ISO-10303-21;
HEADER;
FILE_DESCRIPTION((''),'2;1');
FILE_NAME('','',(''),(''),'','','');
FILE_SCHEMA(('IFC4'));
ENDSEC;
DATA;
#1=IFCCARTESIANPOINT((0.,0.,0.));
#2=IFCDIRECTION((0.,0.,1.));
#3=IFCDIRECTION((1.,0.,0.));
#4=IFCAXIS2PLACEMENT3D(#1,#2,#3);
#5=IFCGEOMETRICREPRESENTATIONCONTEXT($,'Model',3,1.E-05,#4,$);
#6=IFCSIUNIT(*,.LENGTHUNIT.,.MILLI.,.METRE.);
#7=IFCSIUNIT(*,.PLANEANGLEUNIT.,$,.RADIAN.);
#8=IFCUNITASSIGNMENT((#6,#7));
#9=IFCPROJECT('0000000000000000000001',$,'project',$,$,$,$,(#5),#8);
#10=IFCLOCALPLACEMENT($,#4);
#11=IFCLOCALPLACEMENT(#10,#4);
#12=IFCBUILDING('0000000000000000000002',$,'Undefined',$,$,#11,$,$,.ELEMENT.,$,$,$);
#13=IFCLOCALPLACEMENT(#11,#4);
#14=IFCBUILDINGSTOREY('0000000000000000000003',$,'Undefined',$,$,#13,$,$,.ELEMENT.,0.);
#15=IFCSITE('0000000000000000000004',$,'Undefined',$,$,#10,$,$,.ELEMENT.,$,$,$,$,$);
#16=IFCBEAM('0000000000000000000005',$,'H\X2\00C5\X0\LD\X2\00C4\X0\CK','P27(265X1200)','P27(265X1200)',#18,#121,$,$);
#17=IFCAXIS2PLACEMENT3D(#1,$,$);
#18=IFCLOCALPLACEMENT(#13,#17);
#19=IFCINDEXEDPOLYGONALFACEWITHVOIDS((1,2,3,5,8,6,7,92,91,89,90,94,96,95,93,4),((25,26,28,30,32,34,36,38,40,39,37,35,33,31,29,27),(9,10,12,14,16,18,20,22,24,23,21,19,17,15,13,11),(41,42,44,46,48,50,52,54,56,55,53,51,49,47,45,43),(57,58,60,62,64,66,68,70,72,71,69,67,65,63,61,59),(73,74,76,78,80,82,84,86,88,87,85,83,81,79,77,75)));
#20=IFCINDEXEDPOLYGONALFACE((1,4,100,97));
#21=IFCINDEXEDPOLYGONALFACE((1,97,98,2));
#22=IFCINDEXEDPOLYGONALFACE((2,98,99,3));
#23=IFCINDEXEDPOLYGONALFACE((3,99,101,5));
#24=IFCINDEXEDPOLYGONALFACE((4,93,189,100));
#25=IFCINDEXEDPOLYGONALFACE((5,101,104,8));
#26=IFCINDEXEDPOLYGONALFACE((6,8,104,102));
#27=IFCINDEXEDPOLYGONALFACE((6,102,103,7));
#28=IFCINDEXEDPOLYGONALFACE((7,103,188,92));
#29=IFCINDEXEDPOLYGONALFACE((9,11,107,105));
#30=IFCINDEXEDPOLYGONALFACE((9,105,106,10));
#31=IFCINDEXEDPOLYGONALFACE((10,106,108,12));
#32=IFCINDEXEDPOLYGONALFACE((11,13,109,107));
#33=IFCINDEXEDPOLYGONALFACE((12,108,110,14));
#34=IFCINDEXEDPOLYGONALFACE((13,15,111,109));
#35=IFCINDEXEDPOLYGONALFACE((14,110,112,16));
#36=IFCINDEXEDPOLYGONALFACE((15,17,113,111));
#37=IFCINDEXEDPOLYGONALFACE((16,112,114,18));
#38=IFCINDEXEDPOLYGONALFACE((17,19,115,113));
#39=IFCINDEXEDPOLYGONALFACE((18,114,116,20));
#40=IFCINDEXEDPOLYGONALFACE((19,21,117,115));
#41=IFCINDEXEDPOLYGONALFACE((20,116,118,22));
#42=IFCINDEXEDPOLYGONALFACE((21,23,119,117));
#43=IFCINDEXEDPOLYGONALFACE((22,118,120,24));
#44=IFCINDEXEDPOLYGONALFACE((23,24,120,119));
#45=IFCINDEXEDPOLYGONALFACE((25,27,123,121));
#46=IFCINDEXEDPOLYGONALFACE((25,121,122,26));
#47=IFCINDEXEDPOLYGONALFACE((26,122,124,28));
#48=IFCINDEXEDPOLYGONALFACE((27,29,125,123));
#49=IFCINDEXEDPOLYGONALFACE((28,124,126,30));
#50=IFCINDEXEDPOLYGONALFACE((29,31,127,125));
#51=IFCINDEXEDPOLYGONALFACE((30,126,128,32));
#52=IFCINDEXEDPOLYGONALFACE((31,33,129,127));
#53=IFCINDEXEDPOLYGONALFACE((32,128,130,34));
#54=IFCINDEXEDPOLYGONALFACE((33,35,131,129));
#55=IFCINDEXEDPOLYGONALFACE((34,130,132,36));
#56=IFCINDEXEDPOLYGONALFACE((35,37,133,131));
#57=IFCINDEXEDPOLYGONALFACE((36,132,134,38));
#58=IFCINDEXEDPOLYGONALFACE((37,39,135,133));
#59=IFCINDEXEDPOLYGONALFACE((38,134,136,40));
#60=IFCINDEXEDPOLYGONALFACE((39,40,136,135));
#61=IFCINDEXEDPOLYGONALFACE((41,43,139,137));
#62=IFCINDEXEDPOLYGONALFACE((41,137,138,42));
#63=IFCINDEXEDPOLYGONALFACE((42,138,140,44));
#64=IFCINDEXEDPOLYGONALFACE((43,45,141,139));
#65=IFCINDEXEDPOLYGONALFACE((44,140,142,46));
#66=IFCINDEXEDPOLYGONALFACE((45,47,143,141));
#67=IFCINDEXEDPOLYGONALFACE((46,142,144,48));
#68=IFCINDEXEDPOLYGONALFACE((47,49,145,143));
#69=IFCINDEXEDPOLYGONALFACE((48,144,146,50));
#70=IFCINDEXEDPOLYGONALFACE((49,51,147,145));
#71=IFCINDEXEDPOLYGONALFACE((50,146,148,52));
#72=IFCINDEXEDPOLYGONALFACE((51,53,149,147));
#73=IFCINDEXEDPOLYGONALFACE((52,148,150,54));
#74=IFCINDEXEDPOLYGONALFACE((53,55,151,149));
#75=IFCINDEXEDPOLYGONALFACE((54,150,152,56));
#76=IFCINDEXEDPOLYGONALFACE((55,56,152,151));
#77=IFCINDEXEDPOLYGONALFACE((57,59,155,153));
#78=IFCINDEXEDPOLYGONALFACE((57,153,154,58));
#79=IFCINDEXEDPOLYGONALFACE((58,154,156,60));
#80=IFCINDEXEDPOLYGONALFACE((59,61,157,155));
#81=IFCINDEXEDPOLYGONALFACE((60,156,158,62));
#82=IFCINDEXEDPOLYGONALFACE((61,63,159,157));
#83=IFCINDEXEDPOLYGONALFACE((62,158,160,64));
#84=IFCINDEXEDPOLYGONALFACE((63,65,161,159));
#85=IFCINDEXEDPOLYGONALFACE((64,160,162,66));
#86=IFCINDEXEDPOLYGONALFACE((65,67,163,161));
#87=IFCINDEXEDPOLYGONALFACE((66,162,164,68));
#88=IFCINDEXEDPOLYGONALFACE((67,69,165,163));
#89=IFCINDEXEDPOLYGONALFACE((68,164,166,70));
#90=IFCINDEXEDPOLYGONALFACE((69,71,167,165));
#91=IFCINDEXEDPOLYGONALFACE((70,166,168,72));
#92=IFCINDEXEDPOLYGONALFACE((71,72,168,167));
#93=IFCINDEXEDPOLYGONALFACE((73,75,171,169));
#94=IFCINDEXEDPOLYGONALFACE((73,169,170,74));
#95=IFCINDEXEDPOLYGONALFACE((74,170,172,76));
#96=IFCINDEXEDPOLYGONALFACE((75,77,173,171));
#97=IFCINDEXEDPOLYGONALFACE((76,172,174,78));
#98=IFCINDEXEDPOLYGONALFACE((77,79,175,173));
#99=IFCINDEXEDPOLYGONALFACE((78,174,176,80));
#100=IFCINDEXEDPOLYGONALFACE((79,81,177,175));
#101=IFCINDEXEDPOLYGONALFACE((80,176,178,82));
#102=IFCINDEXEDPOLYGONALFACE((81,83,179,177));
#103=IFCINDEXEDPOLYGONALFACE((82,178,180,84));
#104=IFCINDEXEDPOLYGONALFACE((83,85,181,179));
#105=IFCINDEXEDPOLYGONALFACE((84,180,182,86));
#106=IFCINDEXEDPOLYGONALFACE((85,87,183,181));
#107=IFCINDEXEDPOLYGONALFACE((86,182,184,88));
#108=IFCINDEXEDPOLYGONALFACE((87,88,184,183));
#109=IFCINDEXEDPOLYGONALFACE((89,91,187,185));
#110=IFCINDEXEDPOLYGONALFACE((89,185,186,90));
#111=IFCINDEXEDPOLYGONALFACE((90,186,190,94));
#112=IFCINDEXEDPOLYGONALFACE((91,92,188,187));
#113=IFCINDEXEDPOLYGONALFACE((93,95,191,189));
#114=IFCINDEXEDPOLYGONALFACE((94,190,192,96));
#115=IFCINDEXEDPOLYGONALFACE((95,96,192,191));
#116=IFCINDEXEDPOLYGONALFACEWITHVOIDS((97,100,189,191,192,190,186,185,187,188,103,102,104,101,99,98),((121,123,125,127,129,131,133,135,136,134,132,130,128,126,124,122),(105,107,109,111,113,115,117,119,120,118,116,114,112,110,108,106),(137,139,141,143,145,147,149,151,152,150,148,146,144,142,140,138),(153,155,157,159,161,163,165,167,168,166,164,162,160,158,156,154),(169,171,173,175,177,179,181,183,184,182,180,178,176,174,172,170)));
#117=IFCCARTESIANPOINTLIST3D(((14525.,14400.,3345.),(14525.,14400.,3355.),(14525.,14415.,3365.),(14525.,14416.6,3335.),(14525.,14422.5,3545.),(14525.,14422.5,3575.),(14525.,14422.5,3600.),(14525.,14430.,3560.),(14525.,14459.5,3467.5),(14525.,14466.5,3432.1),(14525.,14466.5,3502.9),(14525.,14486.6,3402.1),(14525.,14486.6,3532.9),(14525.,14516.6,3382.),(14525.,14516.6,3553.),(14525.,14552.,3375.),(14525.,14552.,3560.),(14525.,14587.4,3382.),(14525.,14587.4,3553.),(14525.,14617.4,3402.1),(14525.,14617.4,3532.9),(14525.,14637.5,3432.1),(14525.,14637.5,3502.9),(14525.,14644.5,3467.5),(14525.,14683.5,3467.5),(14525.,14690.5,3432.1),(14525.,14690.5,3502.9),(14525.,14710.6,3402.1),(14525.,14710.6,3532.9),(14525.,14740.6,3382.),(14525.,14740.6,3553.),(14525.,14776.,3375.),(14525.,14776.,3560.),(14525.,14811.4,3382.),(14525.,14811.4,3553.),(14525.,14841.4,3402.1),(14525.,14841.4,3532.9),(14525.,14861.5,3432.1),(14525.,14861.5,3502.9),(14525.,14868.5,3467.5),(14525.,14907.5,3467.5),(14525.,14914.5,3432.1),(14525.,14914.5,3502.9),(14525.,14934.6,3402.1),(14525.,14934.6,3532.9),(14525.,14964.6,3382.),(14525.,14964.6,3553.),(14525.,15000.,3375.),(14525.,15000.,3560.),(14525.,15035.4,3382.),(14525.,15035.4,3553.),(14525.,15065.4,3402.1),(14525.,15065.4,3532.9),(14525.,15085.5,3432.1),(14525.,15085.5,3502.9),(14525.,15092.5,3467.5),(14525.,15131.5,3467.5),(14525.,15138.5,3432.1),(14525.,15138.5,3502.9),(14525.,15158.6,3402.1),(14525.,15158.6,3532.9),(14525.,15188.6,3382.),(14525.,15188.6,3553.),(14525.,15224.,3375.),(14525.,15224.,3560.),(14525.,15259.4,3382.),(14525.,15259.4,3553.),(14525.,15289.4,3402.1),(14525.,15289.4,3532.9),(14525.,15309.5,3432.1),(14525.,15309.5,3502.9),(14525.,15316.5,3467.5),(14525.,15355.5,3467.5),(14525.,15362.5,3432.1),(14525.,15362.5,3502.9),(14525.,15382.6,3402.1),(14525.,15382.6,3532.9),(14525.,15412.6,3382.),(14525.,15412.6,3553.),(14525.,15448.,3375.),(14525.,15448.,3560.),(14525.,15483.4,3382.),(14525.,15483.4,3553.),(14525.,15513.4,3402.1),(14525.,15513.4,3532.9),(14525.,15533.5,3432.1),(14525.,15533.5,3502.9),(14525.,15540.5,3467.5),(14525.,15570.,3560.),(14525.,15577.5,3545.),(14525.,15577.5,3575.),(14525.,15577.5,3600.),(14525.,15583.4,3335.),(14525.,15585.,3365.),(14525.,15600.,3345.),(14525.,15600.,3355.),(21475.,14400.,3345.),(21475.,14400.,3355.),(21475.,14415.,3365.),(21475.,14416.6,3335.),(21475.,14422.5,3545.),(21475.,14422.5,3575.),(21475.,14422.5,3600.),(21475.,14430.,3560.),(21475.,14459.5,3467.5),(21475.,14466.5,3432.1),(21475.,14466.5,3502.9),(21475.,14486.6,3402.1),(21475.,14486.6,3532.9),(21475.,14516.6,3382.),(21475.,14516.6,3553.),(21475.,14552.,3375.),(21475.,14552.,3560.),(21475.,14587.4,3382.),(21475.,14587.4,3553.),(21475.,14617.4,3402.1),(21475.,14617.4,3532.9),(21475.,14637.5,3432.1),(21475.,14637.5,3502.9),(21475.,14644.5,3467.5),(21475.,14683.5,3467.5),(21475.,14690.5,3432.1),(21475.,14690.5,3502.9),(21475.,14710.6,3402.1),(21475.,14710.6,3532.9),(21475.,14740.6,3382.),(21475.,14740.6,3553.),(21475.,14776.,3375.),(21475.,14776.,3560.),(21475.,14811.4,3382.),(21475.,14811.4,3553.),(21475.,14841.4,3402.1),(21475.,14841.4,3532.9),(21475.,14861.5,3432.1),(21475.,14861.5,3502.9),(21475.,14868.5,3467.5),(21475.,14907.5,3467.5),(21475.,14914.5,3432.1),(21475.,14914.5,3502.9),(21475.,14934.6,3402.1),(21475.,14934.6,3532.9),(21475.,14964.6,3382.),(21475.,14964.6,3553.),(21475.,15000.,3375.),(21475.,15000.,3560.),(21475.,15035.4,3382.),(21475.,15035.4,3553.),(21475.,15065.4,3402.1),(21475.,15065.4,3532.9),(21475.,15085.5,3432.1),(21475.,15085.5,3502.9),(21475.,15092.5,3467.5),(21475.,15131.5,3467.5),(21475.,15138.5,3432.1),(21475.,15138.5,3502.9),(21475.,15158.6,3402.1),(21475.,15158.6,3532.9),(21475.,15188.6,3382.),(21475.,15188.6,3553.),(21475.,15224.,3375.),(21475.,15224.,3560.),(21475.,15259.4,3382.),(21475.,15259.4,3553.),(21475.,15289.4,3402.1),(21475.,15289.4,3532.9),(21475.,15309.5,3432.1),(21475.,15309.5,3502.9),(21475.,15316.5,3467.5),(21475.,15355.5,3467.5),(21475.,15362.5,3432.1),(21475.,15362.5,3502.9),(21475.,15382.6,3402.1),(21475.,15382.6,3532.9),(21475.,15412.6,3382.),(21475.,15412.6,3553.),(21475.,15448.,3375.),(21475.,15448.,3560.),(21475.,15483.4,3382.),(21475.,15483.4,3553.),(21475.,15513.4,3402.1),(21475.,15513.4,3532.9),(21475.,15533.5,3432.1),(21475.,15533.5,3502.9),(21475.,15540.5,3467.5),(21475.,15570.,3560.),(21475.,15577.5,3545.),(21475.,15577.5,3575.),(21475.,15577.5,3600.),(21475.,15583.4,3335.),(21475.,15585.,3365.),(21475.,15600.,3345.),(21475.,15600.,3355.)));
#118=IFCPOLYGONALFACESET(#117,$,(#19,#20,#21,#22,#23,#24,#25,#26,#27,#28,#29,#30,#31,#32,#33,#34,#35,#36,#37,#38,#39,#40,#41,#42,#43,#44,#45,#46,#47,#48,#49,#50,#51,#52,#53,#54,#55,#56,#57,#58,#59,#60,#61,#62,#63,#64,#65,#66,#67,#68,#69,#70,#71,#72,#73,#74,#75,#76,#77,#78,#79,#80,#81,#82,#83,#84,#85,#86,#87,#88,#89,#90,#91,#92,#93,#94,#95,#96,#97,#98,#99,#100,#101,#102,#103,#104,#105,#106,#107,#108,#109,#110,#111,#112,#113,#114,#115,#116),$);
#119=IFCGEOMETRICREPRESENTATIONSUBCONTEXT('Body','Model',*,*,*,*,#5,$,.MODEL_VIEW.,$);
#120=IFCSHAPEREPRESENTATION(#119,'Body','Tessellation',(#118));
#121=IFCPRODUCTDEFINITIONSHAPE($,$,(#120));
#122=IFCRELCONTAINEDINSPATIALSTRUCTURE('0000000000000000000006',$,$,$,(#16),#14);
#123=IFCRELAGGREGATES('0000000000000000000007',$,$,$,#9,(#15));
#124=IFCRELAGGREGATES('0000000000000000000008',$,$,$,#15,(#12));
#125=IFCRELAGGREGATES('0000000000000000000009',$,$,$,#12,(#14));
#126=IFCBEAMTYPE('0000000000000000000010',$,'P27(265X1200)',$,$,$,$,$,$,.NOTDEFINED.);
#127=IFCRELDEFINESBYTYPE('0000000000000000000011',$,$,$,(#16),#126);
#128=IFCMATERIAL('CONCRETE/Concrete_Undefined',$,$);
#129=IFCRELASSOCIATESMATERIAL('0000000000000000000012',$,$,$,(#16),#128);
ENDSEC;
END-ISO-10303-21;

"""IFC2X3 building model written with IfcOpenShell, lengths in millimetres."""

from ifc_helpers import new_model, si_unit, frame, origin_with_axes, place, context, subcontext, project, spatial, polyline, outline, extrude, material, type_object, element, save


model = new_model("IFC2X3")

# Units and contexts
model_context = context("Model", 3, precision=1e-05, world=origin_with_axes())
body_context = subcontext(model_context, "Body", "Model", "MODEL_VIEW")
ifc_project = project(units=[si_unit("LENGTHUNIT", "METRE", prefix="MILLI"), si_unit("PLANEANGLEUNIT", "RADIAN")], contexts=[model_context])

# Site, building, storey
site_placement = place(None, origin_with_axes())
site = spatial("IfcSite", under=ifc_project, at=site_placement, Name="Undefined", CompositionType="ELEMENT")
building_placement = place(site_placement, origin_with_axes())
building = spatial("IfcBuilding", under=site, at=building_placement, Name="Undefined", CompositionType="ELEMENT")
storey_placement = place(building_placement, origin_with_axes())
storey = spatial("IfcBuildingStorey", under=building, at=storey_placement, Name="Undefined", CompositionType="ELEMENT", Elevation=0.0)

# Beam
ifc_material_1 = material(Name="CONCRETE/Concrete_Undefined")
beam_type_1 = type_object("IfcBeamType", Name="P27(265X1200)", PredefinedType="NOTDEFINED")
beam_1_placement = place(storey_placement, frame((14525.0, 15000.0, 3467.5), z_axis=(0.0, 0.0, 1.0), x_axis=(1.0, 0.0, 0.0)))
element("IfcBeam", 1, at=beam_1_placement, inside=storey, type_object=beam_type_1, material=ifc_material_1, Name="HÅLDÄCK", Description="P27(265X1200)", ObjectType="P27(265X1200)", context=body_context, shape_type="SweptSolid", body=[
    extrude(outline(polyline([(-583.4, -132.5), (-600.0, -122.5), (-600.0, -112.5), (-585.0, -102.5), (-577.5, 77.5), (-570.0, 92.5), (-577.5, 107.5), (-577.5, 132.5), (577.5, 132.5), (577.5, 107.5), (570.0, 92.5), (577.5, 77.5), (585.0, -102.5), (600.0, -112.5), (600.0, -122.5), (583.4, -132.5), (-583.4, -132.5)]), holes=[polyline([(-513.4, 65.4), (-533.5, 35.4), (-540.5, 0.0), (-533.5, -35.4), (-513.4, -65.4), (-483.4, -85.5), (-448.0, -92.5), (-412.6, -85.5), (-382.6, -65.4), (-362.5, -35.4), (-355.5, 0.0), (-362.5, 35.4), (-382.6, 65.4), (-412.6, 85.5), (-448.0, 92.5), (-483.4, 85.5), (-513.4, 65.4)]), polyline([(-289.4, 65.4), (-309.5, 35.4), (-316.5, 0.0), (-309.5, -35.4), (-289.4, -65.4), (-259.4, -85.5), (-224.0, -92.5), (-188.6, -85.5), (-158.6, -65.4), (-138.5, -35.4), (-131.5, 0.0), (-138.5, 35.4), (-158.6, 65.4), (-188.6, 85.5), (-224.0, 92.5), (-259.4, 85.5), (-289.4, 65.4)]), polyline([(-65.4, 65.4), (-85.5, 35.4), (-92.5, 0.0), (-85.5, -35.4), (-65.4, -65.4), (-35.4, -85.5), (0.0, -92.5), (35.4, -85.5), (65.4, -65.4), (85.5, -35.4), (92.5, 0.0), (85.5, 35.4), (65.4, 65.4), (35.4, 85.5), (0.0, 92.5), (-35.4, 85.5), (-65.4, 65.4)]), polyline([(158.6, 65.4), (138.5, 35.4), (131.5, 0.0), (138.5, -35.4), (158.6, -65.4), (188.6, -85.5), (224.0, -92.5), (259.4, -85.5), (289.4, -65.4), (309.5, -35.4), (316.5, 0.0), (309.5, 35.4), (289.4, 65.4), (259.4, 85.5), (224.0, 92.5), (188.6, 85.5), (158.6, 65.4)]), polyline([(382.6, 65.4), (362.5, 35.4), (355.5, 0.0), (362.5, -35.4), (382.6, -65.4), (412.6, -85.5), (448.0, -92.5), (483.4, -85.5), (513.4, -65.4), (533.5, -35.4), (540.5, 0.0), (533.5, 35.4), (513.4, 65.4), (483.4, 85.5), (448.0, 92.5), (412.6, 85.5), (382.6, 65.4)])]), frame((6950.0, 0.0, 0.0), z_axis=(-1.0, 0.0, 0.0), x_axis=(0.0, -1.0, 0.0)), (0.0, 0.0, 1.0), 6950.0),
])

save(model, "model.ifc")
